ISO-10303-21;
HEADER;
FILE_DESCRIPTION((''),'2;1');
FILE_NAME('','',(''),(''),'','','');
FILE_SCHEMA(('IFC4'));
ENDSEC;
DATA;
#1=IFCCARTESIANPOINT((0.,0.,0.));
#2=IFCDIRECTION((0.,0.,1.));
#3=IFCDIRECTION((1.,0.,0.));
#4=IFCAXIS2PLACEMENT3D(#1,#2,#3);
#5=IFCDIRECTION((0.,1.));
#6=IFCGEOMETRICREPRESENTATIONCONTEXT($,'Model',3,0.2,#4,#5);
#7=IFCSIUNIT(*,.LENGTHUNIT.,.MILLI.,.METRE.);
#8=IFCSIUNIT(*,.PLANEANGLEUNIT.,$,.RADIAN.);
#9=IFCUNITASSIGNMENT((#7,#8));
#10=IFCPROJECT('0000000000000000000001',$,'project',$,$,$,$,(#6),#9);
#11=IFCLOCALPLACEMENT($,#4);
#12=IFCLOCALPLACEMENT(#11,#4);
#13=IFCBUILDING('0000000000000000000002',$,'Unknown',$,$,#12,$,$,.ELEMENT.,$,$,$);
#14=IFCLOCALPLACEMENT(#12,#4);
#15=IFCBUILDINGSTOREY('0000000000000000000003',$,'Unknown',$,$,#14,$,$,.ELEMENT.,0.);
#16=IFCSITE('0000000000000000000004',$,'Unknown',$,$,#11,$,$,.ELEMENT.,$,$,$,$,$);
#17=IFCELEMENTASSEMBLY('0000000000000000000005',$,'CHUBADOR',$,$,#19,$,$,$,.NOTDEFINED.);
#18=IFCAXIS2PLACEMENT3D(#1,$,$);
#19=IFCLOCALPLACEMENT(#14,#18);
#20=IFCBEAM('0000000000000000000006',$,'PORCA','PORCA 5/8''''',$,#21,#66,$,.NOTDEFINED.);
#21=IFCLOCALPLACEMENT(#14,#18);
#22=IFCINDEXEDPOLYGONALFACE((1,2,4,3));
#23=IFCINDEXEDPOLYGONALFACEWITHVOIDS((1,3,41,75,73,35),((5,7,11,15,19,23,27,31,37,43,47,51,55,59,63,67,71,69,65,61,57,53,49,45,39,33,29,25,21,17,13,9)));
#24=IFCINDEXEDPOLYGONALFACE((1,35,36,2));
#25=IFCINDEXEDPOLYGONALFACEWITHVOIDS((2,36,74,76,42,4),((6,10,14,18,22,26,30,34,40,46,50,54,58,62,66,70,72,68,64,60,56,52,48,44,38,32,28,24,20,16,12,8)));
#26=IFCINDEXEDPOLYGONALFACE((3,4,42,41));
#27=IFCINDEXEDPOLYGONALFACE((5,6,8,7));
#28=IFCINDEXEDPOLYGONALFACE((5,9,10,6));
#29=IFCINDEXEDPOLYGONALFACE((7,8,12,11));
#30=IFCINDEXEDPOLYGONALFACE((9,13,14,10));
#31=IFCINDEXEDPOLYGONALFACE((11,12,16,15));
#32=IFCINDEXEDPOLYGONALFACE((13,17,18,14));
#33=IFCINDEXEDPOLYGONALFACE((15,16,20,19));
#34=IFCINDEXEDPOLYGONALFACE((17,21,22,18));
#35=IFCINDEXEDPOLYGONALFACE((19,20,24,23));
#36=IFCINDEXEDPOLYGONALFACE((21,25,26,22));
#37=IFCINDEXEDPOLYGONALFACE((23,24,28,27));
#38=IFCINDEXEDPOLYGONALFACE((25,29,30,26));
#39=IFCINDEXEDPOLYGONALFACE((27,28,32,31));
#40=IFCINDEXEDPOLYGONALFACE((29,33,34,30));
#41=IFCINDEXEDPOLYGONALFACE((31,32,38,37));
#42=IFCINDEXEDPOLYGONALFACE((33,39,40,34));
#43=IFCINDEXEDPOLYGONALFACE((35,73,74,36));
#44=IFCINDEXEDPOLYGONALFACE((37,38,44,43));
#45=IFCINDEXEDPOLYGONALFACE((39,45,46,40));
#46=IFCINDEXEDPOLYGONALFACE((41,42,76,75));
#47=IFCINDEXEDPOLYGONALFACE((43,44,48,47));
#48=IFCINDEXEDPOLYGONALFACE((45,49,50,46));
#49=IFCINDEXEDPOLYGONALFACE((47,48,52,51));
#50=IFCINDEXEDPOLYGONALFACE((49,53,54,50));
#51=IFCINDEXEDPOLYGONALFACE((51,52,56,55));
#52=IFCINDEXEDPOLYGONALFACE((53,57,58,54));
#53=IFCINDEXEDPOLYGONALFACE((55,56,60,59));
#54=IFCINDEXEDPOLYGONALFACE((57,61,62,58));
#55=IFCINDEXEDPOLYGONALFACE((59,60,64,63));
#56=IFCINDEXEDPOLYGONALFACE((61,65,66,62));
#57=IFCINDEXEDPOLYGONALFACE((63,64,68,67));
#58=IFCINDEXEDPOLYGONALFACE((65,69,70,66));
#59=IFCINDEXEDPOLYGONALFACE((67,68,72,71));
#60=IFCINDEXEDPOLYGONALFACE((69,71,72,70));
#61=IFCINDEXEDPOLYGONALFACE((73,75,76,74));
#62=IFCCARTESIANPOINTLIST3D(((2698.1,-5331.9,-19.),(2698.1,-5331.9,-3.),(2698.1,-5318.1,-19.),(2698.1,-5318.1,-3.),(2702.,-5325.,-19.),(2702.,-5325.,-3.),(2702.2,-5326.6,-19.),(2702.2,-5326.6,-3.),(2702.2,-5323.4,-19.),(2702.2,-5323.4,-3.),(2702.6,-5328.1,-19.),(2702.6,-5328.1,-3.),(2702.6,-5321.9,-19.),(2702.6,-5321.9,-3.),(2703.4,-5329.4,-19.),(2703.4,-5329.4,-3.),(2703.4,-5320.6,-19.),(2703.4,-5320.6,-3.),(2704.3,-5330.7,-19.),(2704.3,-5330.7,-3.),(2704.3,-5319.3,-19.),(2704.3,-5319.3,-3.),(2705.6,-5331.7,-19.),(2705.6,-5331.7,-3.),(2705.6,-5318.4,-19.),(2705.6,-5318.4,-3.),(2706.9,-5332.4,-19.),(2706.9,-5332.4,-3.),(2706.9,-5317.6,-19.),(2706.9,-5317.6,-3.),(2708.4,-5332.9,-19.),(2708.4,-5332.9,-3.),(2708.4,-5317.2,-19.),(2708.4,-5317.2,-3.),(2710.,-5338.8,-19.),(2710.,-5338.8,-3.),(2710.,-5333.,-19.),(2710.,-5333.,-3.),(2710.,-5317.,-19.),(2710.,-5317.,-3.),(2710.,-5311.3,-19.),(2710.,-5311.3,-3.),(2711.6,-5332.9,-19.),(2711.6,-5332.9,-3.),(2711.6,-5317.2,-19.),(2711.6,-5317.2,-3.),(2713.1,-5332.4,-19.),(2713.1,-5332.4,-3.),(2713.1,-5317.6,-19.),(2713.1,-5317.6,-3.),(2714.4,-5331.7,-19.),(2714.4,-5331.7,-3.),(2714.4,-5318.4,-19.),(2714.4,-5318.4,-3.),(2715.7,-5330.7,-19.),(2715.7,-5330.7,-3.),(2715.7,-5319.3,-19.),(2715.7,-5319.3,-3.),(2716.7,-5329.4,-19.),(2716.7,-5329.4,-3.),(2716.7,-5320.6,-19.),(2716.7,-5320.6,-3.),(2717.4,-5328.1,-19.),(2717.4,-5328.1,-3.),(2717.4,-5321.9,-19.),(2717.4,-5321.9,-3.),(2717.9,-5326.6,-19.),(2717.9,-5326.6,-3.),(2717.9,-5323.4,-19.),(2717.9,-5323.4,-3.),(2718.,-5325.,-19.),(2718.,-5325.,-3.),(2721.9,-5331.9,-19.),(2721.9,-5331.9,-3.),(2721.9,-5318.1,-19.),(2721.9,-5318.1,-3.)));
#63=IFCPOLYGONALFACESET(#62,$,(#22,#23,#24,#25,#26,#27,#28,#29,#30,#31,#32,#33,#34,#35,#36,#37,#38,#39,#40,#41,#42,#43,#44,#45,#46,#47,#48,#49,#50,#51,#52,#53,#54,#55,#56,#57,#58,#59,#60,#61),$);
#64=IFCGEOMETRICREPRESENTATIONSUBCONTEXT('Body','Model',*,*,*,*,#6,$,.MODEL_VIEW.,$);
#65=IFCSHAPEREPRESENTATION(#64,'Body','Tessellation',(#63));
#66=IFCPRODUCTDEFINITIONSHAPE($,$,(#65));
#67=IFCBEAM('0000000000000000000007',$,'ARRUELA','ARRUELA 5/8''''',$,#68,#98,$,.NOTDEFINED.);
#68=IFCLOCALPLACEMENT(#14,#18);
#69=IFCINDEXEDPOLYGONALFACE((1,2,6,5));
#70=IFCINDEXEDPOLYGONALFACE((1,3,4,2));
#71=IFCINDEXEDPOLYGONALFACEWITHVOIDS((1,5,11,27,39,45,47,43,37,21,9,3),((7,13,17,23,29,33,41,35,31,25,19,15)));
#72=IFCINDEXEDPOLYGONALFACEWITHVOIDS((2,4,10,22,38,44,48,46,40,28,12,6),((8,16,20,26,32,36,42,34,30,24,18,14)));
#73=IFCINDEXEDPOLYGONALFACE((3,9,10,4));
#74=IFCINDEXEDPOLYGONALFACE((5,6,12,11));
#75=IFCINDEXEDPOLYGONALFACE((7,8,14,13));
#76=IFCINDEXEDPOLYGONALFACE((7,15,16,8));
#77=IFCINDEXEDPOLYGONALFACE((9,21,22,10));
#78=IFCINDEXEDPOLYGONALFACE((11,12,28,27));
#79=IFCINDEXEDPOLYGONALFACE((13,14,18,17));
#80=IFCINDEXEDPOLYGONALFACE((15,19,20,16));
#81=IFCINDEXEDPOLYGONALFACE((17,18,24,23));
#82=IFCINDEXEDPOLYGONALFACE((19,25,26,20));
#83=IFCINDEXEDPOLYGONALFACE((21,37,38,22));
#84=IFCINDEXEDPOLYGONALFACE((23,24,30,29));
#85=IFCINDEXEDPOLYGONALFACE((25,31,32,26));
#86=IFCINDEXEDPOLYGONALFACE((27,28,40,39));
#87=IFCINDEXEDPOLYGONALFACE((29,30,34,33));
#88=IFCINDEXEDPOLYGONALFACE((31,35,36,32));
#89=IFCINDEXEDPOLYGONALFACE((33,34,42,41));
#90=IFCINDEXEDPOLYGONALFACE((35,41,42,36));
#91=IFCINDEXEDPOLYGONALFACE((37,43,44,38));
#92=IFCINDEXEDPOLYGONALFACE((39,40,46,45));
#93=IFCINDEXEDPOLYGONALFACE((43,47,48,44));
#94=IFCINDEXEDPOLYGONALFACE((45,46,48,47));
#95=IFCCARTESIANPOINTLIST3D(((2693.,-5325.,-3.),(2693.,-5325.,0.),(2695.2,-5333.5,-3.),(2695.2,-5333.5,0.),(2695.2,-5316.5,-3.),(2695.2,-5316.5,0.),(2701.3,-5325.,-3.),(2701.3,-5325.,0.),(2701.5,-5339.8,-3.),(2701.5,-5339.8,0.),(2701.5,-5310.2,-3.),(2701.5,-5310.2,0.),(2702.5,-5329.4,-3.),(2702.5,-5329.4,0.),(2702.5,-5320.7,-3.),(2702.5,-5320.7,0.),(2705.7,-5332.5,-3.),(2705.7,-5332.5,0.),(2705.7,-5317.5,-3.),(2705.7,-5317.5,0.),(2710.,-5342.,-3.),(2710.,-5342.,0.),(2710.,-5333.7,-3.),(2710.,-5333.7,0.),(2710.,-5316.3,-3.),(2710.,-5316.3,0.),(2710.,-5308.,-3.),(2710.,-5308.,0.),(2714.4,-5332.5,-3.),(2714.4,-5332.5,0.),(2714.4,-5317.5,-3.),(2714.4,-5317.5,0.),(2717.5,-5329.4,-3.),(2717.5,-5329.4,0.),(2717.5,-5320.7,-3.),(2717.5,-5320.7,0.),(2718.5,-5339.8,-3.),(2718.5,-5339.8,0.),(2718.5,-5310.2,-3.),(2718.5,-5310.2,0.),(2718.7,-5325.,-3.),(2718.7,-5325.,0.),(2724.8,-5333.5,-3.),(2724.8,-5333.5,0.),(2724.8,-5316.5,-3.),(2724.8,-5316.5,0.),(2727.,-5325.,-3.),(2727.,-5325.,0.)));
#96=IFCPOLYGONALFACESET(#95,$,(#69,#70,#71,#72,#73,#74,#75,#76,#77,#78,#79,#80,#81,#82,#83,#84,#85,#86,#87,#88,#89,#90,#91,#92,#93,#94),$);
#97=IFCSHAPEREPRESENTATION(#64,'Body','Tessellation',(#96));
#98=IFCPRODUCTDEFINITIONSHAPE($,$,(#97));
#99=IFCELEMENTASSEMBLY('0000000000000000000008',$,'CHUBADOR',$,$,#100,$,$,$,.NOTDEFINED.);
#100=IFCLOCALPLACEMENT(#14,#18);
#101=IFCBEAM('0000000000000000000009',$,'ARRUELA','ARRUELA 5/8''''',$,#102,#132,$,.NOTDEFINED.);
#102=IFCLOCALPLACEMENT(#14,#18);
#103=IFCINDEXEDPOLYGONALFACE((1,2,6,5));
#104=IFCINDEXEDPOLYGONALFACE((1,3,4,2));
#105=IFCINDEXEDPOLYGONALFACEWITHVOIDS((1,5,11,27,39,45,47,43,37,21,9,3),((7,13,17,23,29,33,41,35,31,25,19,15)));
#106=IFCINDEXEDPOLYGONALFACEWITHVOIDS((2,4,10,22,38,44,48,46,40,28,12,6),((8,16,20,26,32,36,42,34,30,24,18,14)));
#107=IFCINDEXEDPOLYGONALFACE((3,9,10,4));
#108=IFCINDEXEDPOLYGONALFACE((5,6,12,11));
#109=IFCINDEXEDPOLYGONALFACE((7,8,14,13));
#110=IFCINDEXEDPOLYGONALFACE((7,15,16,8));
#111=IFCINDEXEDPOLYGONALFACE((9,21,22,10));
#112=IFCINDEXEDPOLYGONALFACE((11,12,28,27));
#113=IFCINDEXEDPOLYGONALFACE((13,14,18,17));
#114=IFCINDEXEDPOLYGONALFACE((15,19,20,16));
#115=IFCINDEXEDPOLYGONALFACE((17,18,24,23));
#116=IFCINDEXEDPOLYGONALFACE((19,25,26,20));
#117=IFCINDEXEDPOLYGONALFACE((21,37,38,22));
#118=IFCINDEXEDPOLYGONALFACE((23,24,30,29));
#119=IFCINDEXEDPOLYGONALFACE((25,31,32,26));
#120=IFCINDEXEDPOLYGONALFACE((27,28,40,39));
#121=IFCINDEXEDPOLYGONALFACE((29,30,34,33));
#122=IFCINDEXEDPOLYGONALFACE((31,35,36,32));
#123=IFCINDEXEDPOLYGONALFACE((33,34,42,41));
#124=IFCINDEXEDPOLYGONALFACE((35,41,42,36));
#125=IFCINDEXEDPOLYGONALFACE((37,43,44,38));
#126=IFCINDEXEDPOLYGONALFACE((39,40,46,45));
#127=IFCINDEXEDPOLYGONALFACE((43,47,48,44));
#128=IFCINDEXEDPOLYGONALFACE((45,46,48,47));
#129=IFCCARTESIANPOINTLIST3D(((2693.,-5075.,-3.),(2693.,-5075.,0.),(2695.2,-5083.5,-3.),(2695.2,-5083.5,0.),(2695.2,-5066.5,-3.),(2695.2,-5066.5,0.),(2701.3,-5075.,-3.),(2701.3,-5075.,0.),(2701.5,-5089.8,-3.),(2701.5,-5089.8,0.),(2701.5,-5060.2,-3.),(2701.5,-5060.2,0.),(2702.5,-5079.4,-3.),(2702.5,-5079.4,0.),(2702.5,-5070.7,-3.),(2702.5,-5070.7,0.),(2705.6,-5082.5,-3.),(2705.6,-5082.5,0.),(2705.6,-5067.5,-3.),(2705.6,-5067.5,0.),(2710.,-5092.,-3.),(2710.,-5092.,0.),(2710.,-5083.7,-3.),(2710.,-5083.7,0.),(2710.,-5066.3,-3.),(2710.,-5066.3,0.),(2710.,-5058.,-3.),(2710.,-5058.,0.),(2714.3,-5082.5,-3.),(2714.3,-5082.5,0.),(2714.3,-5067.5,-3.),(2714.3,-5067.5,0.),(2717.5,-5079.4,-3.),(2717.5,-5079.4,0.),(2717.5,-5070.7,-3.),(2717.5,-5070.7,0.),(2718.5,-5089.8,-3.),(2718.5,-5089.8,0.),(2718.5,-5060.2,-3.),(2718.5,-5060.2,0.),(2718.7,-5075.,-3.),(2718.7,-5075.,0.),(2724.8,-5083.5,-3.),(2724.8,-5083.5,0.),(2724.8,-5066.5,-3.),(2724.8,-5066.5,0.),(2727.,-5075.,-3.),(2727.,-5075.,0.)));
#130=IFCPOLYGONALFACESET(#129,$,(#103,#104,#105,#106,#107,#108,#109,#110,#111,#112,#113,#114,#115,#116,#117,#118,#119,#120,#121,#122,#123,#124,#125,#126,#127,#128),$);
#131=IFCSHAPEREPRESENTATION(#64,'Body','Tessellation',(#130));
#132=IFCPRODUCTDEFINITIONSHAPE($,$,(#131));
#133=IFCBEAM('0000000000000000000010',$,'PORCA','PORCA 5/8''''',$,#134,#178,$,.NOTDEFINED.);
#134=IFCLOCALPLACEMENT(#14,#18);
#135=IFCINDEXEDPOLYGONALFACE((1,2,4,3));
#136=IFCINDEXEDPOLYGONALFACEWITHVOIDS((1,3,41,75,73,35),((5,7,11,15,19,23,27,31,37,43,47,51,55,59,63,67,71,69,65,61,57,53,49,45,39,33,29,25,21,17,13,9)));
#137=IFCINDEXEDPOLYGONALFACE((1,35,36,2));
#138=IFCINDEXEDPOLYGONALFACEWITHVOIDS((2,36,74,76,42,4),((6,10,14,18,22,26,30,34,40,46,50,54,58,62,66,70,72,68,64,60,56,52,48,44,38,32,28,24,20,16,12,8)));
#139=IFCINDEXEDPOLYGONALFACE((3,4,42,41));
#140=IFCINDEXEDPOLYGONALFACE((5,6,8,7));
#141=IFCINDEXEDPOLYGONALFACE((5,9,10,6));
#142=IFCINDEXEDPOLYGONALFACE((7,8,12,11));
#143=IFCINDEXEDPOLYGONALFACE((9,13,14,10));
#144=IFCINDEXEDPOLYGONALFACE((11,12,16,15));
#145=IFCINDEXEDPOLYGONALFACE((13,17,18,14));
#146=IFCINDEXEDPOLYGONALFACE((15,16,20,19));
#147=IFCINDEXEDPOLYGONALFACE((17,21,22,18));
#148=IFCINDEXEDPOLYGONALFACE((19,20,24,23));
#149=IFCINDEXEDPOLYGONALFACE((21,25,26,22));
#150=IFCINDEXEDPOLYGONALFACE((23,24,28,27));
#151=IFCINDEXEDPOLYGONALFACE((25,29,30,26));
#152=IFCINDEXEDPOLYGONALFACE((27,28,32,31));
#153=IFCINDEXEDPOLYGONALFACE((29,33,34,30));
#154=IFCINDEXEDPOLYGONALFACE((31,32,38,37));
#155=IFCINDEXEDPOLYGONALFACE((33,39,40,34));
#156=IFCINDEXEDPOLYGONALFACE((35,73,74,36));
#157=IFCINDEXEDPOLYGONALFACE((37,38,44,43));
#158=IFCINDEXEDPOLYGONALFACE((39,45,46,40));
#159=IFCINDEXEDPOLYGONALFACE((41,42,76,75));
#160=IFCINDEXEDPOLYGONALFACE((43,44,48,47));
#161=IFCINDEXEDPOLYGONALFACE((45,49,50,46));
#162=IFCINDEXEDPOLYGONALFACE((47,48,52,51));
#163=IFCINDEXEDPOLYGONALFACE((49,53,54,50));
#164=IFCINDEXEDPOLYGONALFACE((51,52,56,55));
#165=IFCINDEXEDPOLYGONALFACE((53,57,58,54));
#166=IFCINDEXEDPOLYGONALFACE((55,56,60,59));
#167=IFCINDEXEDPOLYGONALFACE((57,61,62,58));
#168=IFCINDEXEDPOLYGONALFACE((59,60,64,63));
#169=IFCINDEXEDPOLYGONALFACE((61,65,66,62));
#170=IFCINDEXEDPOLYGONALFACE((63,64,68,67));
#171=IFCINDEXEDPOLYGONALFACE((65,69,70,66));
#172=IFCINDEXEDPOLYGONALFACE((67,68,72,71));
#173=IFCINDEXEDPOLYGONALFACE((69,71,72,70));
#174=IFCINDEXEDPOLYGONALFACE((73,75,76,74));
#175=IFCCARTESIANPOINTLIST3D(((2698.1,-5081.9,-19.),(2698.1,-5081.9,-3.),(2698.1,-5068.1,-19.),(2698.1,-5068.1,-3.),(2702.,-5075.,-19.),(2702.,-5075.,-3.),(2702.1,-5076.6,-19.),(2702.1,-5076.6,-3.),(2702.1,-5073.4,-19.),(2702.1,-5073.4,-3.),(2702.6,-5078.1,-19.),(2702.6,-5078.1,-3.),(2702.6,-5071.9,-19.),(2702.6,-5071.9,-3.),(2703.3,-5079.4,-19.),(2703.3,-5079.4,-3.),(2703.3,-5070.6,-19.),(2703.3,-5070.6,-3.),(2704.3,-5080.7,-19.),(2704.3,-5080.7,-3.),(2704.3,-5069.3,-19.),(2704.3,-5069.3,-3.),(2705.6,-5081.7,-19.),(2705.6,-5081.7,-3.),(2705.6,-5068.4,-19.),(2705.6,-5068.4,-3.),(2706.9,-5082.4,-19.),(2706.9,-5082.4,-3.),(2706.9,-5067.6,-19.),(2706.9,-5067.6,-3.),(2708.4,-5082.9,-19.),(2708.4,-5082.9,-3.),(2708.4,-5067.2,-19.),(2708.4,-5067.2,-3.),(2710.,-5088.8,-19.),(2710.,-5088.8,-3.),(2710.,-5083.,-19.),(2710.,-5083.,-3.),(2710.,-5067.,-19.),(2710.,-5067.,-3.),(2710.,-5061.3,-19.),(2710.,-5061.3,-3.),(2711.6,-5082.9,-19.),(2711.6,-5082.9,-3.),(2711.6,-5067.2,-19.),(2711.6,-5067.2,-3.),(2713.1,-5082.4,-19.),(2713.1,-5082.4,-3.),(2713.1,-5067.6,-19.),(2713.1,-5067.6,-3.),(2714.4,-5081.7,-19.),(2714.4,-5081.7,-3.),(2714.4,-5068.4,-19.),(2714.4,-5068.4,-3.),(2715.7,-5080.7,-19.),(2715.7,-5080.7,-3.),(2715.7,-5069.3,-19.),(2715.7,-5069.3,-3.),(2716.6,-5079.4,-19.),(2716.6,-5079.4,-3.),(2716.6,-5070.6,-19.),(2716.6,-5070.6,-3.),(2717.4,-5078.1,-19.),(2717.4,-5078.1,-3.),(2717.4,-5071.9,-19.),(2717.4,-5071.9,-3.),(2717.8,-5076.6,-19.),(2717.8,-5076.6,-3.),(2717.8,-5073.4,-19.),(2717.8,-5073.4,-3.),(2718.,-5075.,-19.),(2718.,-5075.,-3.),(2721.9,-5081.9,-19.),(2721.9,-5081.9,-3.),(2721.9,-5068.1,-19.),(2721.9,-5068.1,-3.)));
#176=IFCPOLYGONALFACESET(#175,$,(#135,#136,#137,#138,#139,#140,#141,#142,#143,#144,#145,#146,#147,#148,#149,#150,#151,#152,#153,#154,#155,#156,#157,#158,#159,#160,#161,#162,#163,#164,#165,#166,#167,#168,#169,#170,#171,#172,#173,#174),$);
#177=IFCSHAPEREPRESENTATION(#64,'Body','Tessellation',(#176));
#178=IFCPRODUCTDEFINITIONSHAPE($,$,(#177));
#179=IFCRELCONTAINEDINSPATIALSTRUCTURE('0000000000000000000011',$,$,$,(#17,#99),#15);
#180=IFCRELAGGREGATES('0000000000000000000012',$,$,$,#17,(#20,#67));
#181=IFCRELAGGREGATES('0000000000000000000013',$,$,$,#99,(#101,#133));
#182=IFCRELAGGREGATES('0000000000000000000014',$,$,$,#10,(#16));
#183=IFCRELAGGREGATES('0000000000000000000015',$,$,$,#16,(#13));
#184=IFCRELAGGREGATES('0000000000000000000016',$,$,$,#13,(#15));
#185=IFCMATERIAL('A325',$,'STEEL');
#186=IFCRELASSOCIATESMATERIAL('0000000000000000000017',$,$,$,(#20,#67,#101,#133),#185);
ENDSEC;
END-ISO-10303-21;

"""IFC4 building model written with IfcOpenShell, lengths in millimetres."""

from ifc_helpers import new_model, si_unit, direction, frame, origin_with_axes, place, context, subcontext, project, spatial, line, indexed_curve, outline, extrude, material, element, aggregate, save


model = new_model("IFC4")

# Units and contexts
model_context = context("Model", 3, precision=0.2, world=origin_with_axes(), true_north=direction((0.0, 1.0)))
body_context = subcontext(model_context, "Body", "Model", "MODEL_VIEW")
ifc_project = project(units=[si_unit("LENGTHUNIT", "METRE", prefix="MILLI"), si_unit("PLANEANGLEUNIT", "RADIAN")], contexts=[model_context])

# Site, building, storey
site_placement = place(None, origin_with_axes())
site = spatial("IfcSite", under=ifc_project, at=site_placement, Name="Unknown", CompositionType="ELEMENT")
building_placement = place(site_placement, origin_with_axes())
building = spatial("IfcBuilding", under=site, at=building_placement, Name="Unknown", CompositionType="ELEMENT")
storey_placement = place(building_placement, origin_with_axes())
storey = spatial("IfcBuildingStorey", under=building, at=storey_placement, Name="Unknown", CompositionType="ELEMENT", Elevation=0.0)

# Shared definitions
ifc_material_1 = material(Name="A325", Category="STEEL")

# Element assemblies, beams
assembly_1_placement = place(storey_placement, frame((2710.0, -5325.0, -52.1), z_axis=(-1.0, 0.0, 0.0), x_axis=(0.0, 0.0, -1.0)))
assembly_1 = element("IfcElementAssembly", 1, at=assembly_1_placement, inside=storey, Name="CHUBADOR", PredefinedType="NOTDEFINED")
beam_1_placement = place(assembly_1_placement, frame((-49.1, 0.0, 0.0), z_axis=(0.0, 0.0, 1.0), x_axis=(1.0, 0.0, 0.0)))
beam_1 = element("IfcBeam", 2, at=beam_1_placement, material=ifc_material_1, Name="PORCA", Description="PORCA 5/8''", PredefinedType="NOTDEFINED", context=body_context, shape_type="SolidModel", body=[
    extrude(outline(indexed_curve([(0.0, 13.8), (-11.9, 6.9), (-11.9, -6.9), (0.0, -13.8), (11.9, -6.9), (11.9, 6.9)], segments=[line(1, 2, 3, 4, 5, 6, 1)]), holes=[indexed_curve([(7.8, 1.6), (8.0, 0.0), (7.8, -1.6), (7.4, -3.1), (6.7, -4.4), (5.7, -5.7), (4.4, -6.7), (3.1, -7.4), (1.6, -7.8), (0.0, -8.0), (-1.6, -7.8), (-3.1, -7.4), (-4.4, -6.7), (-5.7, -5.7), (-6.7, -4.4), (-7.4, -3.1), (-7.8, -1.6), (-8.0, 0.0), (-7.8, 1.6), (-7.4, 3.1), (-6.7, 4.4), (-5.7, 5.7), (-4.4, 6.7), (-3.1, 7.4), (-1.6, 7.8), (0.0, 8.0), (1.6, 7.8), (3.1, 7.4), (4.4, 6.7), (5.7, 5.7), (6.7, 4.4), (7.4, 3.1)], segments=[line(1, 2, 3, 4, 5, 6, 7, 8, 9, 10, 11, 12, 13, 14, 15, 16, 17, 18, 19, 20, 21, 22, 23, 24, 25, 26, 27, 28, 29, 30, 31, 32, 1)])]), frame((0.0, 0.0, 0.0), z_axis=(-1.0, 0.0, 0.0), x_axis=(0.0, 0.0, 1.0)), (0.0, 0.0, -1.0), 16.0),
])
beam_2_placement = place(assembly_1_placement, frame((-52.1, 0.0, 0.0), z_axis=(0.0, 0.0, 1.0), x_axis=(1.0, 0.0, 0.0)))
beam_2 = element("IfcBeam", 3, at=beam_2_placement, material=ifc_material_1, Name="ARRUELA", Description="ARRUELA 5/8''", PredefinedType="NOTDEFINED", context=body_context, shape_type="SolidModel", body=[
    extrude(outline(indexed_curve([(17.0, 0.0), (14.8, 8.5), (8.5, 14.8), (0.0, 17.0), (-8.5, 14.8), (-14.8, 8.5), (-17.0, 0.0), (-14.8, -8.5), (-8.5, -14.8), (0.0, -17.0), (8.5, -14.8), (14.8, -8.5)], segments=[line(1, 2, 3, 4, 5, 6, 7, 8, 9, 10, 11, 12, 1)]), holes=[indexed_curve([(8.7, 0.0), (7.5, -4.3), (4.3, -7.5), (0.0, -8.7), (-4.3, -7.5), (-7.5, -4.3), (-8.7, 0.0), (-7.5, 4.3), (-4.3, 7.5), (0.0, 8.7), (4.3, 7.5), (7.5, 4.3)], segments=[line(1, 2, 3, 4, 5, 6, 7, 8, 9, 10, 11, 12, 1)])]), frame((0.0, 0.0, 0.0), z_axis=(-1.0, 0.0, 0.0), x_axis=(0.0, 0.0, 1.0)), (0.0, 0.0, -1.0), 3.0),
])
aggregate(assembly_1, [beam_1, beam_2])
assembly_2_placement = place(storey_placement, frame((2710.0, -5075.0, -52.1), z_axis=(-1.0, 0.0, 0.0), x_axis=(0.0, 0.0, -1.0)))
assembly_2 = element("IfcElementAssembly", 4, at=assembly_2_placement, inside=storey, Name="CHUBADOR", PredefinedType="NOTDEFINED")
beam_3_placement = place(assembly_2_placement, frame((-52.1, 0.0, 0.0), z_axis=(0.0, 0.0, 1.0), x_axis=(1.0, 0.0, 0.0)))
beam_3 = element("IfcBeam", 5, at=beam_3_placement, material=ifc_material_1, Name="ARRUELA", Description="ARRUELA 5/8''", PredefinedType="NOTDEFINED", context=body_context, shape_type="SolidModel", body=[
    extrude(outline(indexed_curve([(17.0, 0.0), (14.8, 8.5), (8.5, 14.8), (0.0, 17.0), (-8.5, 14.8), (-14.8, 8.5), (-17.0, 0.0), (-14.8, -8.5), (-8.5, -14.8), (0.0, -17.0), (8.5, -14.8), (14.8, -8.5)], segments=[line(1, 2, 3, 4, 5, 6, 7, 8, 9, 10, 11, 12, 1)]), holes=[indexed_curve([(8.7, 0.0), (7.5, -4.3), (4.3, -7.5), (0.0, -8.7), (-4.3, -7.5), (-7.5, -4.3), (-8.7, 0.0), (-7.5, 4.3), (-4.3, 7.5), (0.0, 8.7), (4.3, 7.5), (7.5, 4.3)], segments=[line(1, 2, 3, 4, 5, 6, 7, 8, 9, 10, 11, 12, 1)])]), frame((0.0, 0.0, 0.0), z_axis=(-1.0, 0.0, 0.0), x_axis=(0.0, 0.0, 1.0)), (0.0, 0.0, -1.0), 3.0),
])
beam_4_placement = place(assembly_2_placement, frame((-49.1, 0.0, 0.0), z_axis=(0.0, 0.0, 1.0), x_axis=(1.0, 0.0, 0.0)))
beam_4 = element("IfcBeam", 6, at=beam_4_placement, material=ifc_material_1, Name="PORCA", Description="PORCA 5/8''", PredefinedType="NOTDEFINED", context=body_context, shape_type="SolidModel", body=[
    extrude(outline(indexed_curve([(0.0, 13.8), (-11.9, 6.9), (-11.9, -6.9), (0.0, -13.8), (11.9, -6.9), (11.9, 6.9)], segments=[line(1, 2, 3, 4, 5, 6, 1)]), holes=[indexed_curve([(7.8, 1.6), (8.0, 0.0), (7.8, -1.6), (7.4, -3.1), (6.7, -4.4), (5.7, -5.7), (4.4, -6.7), (3.1, -7.4), (1.6, -7.8), (0.0, -8.0), (-1.6, -7.8), (-3.1, -7.4), (-4.4, -6.7), (-5.7, -5.7), (-6.7, -4.4), (-7.4, -3.1), (-7.8, -1.6), (-8.0, 0.0), (-7.8, 1.6), (-7.4, 3.1), (-6.7, 4.4), (-5.7, 5.7), (-4.4, 6.7), (-3.1, 7.4), (-1.6, 7.8), (0.0, 8.0), (1.6, 7.8), (3.1, 7.4), (4.4, 6.7), (5.7, 5.7), (6.7, 4.4), (7.4, 3.1)], segments=[line(1, 2, 3, 4, 5, 6, 7, 8, 9, 10, 11, 12, 13, 14, 15, 16, 17, 18, 19, 20, 21, 22, 23, 24, 25, 26, 27, 28, 29, 30, 31, 32, 1)])]), frame((0.0, 0.0, 0.0), z_axis=(-1.0, 0.0, 0.0), x_axis=(0.0, 0.0, 1.0)), (0.0, 0.0, -1.0), 16.0),
])
aggregate(assembly_2, [beam_3, beam_4])

save(model, "model.ifc")
